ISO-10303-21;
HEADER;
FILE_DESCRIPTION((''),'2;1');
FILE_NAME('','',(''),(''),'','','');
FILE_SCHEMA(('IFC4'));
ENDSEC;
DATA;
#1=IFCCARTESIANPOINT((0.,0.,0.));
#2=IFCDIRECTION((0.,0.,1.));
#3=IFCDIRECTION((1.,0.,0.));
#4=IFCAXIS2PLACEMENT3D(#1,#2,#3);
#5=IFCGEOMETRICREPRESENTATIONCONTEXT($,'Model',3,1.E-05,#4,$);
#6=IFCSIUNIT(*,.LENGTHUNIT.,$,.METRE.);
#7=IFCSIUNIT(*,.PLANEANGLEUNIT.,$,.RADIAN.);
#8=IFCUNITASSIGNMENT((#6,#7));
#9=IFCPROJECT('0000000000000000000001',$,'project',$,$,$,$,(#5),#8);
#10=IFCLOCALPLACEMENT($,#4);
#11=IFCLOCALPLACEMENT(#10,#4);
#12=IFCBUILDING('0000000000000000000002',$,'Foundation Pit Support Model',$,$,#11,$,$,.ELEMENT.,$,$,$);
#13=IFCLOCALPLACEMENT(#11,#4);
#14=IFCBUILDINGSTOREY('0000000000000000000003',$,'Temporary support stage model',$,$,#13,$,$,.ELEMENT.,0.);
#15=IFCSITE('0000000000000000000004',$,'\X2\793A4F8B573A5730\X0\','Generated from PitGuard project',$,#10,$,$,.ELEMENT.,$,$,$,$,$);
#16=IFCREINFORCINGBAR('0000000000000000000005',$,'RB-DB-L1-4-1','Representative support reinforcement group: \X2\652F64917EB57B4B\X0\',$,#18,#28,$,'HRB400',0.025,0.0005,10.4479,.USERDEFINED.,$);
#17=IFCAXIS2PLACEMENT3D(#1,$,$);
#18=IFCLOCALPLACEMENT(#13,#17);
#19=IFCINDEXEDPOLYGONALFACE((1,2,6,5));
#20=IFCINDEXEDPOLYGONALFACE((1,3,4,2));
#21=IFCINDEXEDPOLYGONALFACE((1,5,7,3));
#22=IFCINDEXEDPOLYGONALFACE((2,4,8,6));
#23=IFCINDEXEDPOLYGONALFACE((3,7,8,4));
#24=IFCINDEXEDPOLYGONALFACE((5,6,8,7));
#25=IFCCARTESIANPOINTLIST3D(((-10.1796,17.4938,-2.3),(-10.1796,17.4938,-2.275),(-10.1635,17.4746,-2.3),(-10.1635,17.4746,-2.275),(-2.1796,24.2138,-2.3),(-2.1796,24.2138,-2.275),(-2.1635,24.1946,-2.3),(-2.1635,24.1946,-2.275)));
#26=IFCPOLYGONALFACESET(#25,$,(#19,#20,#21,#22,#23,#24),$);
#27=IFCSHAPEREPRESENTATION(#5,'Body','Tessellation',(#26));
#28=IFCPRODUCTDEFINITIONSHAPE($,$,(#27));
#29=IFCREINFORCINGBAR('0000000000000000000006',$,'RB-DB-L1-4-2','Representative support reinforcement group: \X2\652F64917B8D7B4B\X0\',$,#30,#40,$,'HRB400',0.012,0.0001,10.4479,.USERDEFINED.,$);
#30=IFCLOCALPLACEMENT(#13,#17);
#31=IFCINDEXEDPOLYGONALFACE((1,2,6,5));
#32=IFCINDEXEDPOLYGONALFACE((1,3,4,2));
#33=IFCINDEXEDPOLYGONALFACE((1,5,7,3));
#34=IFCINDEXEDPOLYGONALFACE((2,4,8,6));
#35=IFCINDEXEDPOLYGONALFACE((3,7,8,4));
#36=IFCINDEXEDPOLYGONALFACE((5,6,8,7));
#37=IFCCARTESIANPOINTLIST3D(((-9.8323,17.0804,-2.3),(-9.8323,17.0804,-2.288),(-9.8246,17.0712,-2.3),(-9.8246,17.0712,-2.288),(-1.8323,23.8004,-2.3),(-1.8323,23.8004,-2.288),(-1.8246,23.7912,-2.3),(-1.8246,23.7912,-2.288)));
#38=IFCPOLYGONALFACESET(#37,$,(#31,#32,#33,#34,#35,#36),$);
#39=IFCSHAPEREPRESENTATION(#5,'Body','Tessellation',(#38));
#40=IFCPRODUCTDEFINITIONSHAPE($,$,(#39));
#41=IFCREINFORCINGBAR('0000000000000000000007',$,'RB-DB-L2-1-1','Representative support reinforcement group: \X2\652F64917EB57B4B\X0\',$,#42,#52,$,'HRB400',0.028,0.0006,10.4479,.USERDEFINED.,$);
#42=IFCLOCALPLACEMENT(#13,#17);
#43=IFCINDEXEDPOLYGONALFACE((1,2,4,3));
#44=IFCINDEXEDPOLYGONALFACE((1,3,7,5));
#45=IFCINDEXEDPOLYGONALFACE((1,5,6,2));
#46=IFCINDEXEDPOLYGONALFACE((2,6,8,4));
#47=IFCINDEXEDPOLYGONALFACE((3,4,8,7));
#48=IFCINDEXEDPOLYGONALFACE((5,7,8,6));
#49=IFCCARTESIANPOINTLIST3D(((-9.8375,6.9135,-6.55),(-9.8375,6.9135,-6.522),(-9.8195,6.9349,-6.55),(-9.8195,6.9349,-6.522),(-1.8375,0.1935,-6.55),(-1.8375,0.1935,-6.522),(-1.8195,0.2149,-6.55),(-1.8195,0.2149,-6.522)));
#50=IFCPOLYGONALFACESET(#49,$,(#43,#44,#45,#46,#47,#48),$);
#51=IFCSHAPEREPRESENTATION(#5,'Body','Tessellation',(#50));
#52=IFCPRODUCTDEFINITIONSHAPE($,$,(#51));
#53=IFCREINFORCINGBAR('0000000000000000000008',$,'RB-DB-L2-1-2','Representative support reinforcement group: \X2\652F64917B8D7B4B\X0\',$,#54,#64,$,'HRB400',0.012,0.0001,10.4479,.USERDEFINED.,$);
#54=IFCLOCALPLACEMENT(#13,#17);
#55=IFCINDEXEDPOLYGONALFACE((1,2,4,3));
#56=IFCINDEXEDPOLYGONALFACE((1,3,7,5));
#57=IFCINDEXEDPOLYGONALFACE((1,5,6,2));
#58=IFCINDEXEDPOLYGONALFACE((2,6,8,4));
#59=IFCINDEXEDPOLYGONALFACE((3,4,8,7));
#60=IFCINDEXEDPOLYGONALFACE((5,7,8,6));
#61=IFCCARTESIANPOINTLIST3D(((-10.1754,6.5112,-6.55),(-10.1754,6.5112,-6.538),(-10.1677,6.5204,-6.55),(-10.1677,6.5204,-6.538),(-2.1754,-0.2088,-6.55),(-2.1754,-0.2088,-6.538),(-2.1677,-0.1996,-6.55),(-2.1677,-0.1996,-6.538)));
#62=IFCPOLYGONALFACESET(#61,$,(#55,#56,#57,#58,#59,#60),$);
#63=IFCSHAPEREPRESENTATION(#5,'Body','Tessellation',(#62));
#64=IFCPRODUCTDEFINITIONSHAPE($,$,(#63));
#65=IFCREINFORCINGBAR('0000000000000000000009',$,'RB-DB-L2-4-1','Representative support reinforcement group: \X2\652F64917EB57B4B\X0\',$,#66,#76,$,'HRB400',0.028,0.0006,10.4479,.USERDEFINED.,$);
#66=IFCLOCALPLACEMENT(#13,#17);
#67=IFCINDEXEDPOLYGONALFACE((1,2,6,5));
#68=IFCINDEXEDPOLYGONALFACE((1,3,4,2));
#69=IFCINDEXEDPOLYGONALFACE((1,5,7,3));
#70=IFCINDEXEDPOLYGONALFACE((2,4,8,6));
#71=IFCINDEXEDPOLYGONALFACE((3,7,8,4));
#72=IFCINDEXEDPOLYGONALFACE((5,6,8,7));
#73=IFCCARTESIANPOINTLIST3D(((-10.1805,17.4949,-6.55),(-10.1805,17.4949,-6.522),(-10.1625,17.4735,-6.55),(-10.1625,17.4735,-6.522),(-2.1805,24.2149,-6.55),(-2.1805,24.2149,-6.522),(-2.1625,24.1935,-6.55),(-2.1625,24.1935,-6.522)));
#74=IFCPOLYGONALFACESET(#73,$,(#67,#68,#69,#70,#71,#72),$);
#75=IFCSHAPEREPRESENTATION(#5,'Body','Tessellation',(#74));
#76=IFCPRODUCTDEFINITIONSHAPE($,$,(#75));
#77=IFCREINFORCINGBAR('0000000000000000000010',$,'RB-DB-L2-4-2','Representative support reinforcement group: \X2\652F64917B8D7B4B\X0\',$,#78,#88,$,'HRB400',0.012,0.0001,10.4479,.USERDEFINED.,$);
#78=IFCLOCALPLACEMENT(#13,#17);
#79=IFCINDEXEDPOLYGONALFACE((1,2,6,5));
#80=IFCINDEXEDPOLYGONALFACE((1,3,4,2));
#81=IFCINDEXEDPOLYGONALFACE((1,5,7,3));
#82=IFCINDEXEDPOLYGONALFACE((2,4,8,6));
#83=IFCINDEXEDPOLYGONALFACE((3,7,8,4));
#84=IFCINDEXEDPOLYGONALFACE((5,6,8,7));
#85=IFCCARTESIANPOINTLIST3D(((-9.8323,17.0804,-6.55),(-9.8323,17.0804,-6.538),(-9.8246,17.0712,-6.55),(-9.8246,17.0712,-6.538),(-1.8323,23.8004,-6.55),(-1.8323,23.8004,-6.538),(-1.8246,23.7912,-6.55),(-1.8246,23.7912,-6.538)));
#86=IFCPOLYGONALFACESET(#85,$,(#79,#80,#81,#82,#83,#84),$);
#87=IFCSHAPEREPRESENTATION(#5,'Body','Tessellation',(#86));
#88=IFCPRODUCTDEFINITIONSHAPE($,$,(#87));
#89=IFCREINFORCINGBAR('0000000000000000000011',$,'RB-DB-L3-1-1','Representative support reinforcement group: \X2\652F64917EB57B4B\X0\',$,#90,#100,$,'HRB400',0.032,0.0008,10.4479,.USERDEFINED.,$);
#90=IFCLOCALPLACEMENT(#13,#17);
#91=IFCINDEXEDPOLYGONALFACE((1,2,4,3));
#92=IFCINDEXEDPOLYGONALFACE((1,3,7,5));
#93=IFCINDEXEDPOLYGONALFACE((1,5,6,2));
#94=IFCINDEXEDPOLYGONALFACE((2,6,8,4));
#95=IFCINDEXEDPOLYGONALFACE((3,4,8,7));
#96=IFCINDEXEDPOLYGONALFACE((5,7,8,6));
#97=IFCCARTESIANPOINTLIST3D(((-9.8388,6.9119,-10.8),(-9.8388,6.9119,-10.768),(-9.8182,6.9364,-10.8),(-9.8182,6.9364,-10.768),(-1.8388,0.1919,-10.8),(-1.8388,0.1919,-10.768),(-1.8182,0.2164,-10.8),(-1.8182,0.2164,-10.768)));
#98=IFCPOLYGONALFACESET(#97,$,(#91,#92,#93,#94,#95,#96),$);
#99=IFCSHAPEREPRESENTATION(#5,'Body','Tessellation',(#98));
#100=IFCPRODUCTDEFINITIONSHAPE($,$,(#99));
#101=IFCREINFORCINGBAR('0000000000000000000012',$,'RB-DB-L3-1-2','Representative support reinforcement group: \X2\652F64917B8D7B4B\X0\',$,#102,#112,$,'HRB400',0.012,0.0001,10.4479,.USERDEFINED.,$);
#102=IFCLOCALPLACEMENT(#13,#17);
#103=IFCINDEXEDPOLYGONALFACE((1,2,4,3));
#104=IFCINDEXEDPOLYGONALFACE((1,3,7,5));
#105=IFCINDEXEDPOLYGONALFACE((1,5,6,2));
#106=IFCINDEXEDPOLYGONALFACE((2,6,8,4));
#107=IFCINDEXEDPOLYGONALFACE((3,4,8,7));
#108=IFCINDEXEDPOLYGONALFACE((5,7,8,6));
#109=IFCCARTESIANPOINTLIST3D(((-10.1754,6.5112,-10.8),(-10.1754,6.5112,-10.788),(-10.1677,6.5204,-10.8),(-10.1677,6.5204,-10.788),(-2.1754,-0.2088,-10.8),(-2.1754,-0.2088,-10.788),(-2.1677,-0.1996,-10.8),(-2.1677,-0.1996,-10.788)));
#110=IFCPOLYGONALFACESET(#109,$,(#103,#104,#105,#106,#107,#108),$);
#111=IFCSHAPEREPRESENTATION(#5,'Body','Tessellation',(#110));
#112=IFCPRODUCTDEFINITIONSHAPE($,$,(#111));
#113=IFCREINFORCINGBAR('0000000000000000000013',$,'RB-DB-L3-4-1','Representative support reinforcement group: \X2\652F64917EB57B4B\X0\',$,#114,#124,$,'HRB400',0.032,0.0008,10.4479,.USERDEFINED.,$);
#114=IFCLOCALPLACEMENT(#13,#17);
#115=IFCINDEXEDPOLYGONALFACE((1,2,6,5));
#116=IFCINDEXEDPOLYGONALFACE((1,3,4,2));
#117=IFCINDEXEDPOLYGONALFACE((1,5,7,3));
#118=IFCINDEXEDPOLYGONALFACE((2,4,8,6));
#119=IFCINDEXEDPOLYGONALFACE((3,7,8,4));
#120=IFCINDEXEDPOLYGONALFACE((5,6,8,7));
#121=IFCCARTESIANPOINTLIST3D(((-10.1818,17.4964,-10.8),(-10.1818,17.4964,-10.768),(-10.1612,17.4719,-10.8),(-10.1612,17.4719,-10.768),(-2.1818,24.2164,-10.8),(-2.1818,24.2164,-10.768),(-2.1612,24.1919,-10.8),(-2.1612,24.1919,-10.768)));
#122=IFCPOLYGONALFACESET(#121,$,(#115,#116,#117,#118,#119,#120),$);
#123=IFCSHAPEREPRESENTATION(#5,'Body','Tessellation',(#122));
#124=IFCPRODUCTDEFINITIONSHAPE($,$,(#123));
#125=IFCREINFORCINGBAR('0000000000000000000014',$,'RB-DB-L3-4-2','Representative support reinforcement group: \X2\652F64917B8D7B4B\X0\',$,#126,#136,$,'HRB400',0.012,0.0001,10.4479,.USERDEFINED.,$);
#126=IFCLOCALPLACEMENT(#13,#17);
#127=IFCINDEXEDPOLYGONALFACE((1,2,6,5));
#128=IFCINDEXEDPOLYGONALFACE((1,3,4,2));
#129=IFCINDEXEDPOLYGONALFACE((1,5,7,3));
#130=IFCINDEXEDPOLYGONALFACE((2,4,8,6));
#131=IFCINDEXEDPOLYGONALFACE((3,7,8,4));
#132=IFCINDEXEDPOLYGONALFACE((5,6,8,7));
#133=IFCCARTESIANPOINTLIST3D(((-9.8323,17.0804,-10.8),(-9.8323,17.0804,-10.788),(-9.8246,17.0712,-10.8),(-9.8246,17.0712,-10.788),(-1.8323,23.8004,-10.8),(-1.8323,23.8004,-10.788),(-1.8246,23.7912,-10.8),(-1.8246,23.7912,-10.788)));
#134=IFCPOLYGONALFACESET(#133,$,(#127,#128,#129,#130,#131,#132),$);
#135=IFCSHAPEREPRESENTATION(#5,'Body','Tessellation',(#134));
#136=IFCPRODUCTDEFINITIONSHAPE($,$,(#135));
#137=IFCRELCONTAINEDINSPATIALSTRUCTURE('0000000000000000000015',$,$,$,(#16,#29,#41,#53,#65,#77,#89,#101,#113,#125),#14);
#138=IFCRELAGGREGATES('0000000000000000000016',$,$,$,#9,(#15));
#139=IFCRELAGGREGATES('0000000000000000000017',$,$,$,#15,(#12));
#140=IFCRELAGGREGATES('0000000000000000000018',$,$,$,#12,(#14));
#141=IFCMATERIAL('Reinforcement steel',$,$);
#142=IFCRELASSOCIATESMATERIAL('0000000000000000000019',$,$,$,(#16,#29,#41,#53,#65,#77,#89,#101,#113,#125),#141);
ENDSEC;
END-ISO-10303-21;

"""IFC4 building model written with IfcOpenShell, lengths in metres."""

from ifc_helpers import new_model, si_unit, frame, origin_with_axes, origin_2d, place, context, project, spatial, rectangle, extrude, material, element, save


model = new_model("IFC4")

# Units and contexts
model_context = context("Model", 3, precision=1e-05, world=origin_with_axes())
ifc_project = project(units=[si_unit("LENGTHUNIT", "METRE"), si_unit("PLANEANGLEUNIT", "RADIAN")], contexts=[model_context])

# Site, building, storey
site_placement = place(None, origin_with_axes())
site = spatial("IfcSite", under=ifc_project, at=site_placement, Name="示例场地", Description="Generated from PitGuard project", CompositionType="ELEMENT")
building_placement = place(site_placement, origin_with_axes())
building = spatial("IfcBuilding", under=site, at=building_placement, Name="Foundation Pit Support Model", CompositionType="ELEMENT")
storey_placement = place(building_placement, origin_with_axes())
storey = spatial("IfcBuildingStorey", under=building, at=storey_placement, Name="Temporary support stage model", CompositionType="ELEMENT", Elevation=0.0)

# Reinforcing bars
ifc_material_1 = material(Name="Reinforcement steel")
reinforcing_bar_1_placement = place(storey_placement, frame((-6.1715, 20.8442, -2.3), z_axis=(0.0, 0.0, 1.0), x_axis=(-0.765705, -0.643192, 0.0)))
element("IfcReinforcingBar", 1, at=reinforcing_bar_1_placement, inside=storey, material=ifc_material_1, Name="RB-DB-L1-4-1", Description="Representative support reinforcement group: 支撑纵筋", SteelGrade="HRB400", BarLength=10.4479, CrossSectionArea=0.0005, NominalDiameter=0.025, PredefinedType="USERDEFINED", context=model_context, shape_type="SweptSolid", body=[
    extrude(rectangle(XDim=10.4479, YDim=0.025, at=origin_2d()), origin_with_axes(), (0.0, 0.0, 1.0), 0.025),
])
reinforcing_bar_2_placement = place(storey_placement, frame((-5.8285, 20.4358, -2.3), z_axis=(0.0, 0.0, 1.0), x_axis=(-0.765705, -0.643192, 0.0)))
element("IfcReinforcingBar", 2, at=reinforcing_bar_2_placement, inside=storey, material=ifc_material_1, Name="RB-DB-L1-4-2", Description="Representative support reinforcement group: 支撑箍筋", SteelGrade="HRB400", BarLength=10.4479, CrossSectionArea=0.0001, NominalDiameter=0.012, PredefinedType="USERDEFINED", context=model_context, shape_type="SweptSolid", body=[
    extrude(rectangle(XDim=10.4479, YDim=0.012, at=origin_2d()), origin_with_axes(), (0.0, 0.0, 1.0), 0.012),
])
reinforcing_bar_3_placement = place(storey_placement, frame((-5.8285, 3.5642, -6.55), z_axis=(0.0, 0.0, 1.0), x_axis=(-0.765705, 0.643192, 0.0)))
element("IfcReinforcingBar", 3, at=reinforcing_bar_3_placement, inside=storey, material=ifc_material_1, Name="RB-DB-L2-1-1", Description="Representative support reinforcement group: 支撑纵筋", SteelGrade="HRB400", BarLength=10.4479, CrossSectionArea=0.0006, NominalDiameter=0.028, PredefinedType="USERDEFINED", context=model_context, shape_type="SweptSolid", body=[
    extrude(rectangle(XDim=10.4479, YDim=0.028, at=origin_2d()), origin_with_axes(), (0.0, 0.0, 1.0), 0.028),
])
reinforcing_bar_4_placement = place(storey_placement, frame((-6.1715, 3.1558, -6.55), z_axis=(0.0, 0.0, 1.0), x_axis=(-0.765705, 0.643192, 0.0)))
element("IfcReinforcingBar", 4, at=reinforcing_bar_4_placement, inside=storey, material=ifc_material_1, Name="RB-DB-L2-1-2", Description="Representative support reinforcement group: 支撑箍筋", SteelGrade="HRB400", BarLength=10.4479, CrossSectionArea=0.0001, NominalDiameter=0.012, PredefinedType="USERDEFINED", context=model_context, shape_type="SweptSolid", body=[
    extrude(rectangle(XDim=10.4479, YDim=0.012, at=origin_2d()), origin_with_axes(), (0.0, 0.0, 1.0), 0.012),
])
reinforcing_bar_5_placement = place(storey_placement, frame((-6.1715, 20.8442, -6.55), z_axis=(0.0, 0.0, 1.0), x_axis=(-0.765705, -0.643192, 0.0)))
element("IfcReinforcingBar", 5, at=reinforcing_bar_5_placement, inside=storey, material=ifc_material_1, Name="RB-DB-L2-4-1", Description="Representative support reinforcement group: 支撑纵筋", SteelGrade="HRB400", BarLength=10.4479, CrossSectionArea=0.0006, NominalDiameter=0.028, PredefinedType="USERDEFINED", context=model_context, shape_type="SweptSolid", body=[
    extrude(rectangle(XDim=10.4479, YDim=0.028, at=origin_2d()), origin_with_axes(), (0.0, 0.0, 1.0), 0.028),
])
reinforcing_bar_6_placement = place(storey_placement, frame((-5.8285, 20.4358, -6.55), z_axis=(0.0, 0.0, 1.0), x_axis=(-0.765705, -0.643192, 0.0)))
element("IfcReinforcingBar", 6, at=reinforcing_bar_6_placement, inside=storey, material=ifc_material_1, Name="RB-DB-L2-4-2", Description="Representative support reinforcement group: 支撑箍筋", SteelGrade="HRB400", BarLength=10.4479, CrossSectionArea=0.0001, NominalDiameter=0.012, PredefinedType="USERDEFINED", context=model_context, shape_type="SweptSolid", body=[
    extrude(rectangle(XDim=10.4479, YDim=0.012, at=origin_2d()), origin_with_axes(), (0.0, 0.0, 1.0), 0.012),
])
reinforcing_bar_7_placement = place(storey_placement, frame((-5.8285, 3.5642, -10.8), z_axis=(0.0, 0.0, 1.0), x_axis=(-0.765705, 0.643192, 0.0)))
element("IfcReinforcingBar", 7, at=reinforcing_bar_7_placement, inside=storey, material=ifc_material_1, Name="RB-DB-L3-1-1", Description="Representative support reinforcement group: 支撑纵筋", SteelGrade="HRB400", BarLength=10.4479, CrossSectionArea=0.0008, NominalDiameter=0.032, PredefinedType="USERDEFINED", context=model_context, shape_type="SweptSolid", body=[
    extrude(rectangle(XDim=10.4479, YDim=0.032, at=origin_2d()), origin_with_axes(), (0.0, 0.0, 1.0), 0.032),
])
reinforcing_bar_8_placement = place(storey_placement, frame((-6.1715, 3.1558, -10.8), z_axis=(0.0, 0.0, 1.0), x_axis=(-0.765705, 0.643192, 0.0)))
element("IfcReinforcingBar", 8, at=reinforcing_bar_8_placement, inside=storey, material=ifc_material_1, Name="RB-DB-L3-1-2", Description="Representative support reinforcement group: 支撑箍筋", SteelGrade="HRB400", BarLength=10.4479, CrossSectionArea=0.0001, NominalDiameter=0.012, PredefinedType="USERDEFINED", context=model_context, shape_type="SweptSolid", body=[
    extrude(rectangle(XDim=10.4479, YDim=0.012, at=origin_2d()), origin_with_axes(), (0.0, 0.0, 1.0), 0.012),
])
reinforcing_bar_9_placement = place(storey_placement, frame((-6.1715, 20.8442, -10.8), z_axis=(0.0, 0.0, 1.0), x_axis=(-0.765705, -0.643192, 0.0)))
element("IfcReinforcingBar", 9, at=reinforcing_bar_9_placement, inside=storey, material=ifc_material_1, Name="RB-DB-L3-4-1", Description="Representative support reinforcement group: 支撑纵筋", SteelGrade="HRB400", BarLength=10.4479, CrossSectionArea=0.0008, NominalDiameter=0.032, PredefinedType="USERDEFINED", context=model_context, shape_type="SweptSolid", body=[
    extrude(rectangle(XDim=10.4479, YDim=0.032, at=origin_2d()), origin_with_axes(), (0.0, 0.0, 1.0), 0.032),
])
reinforcing_bar_10_placement = place(storey_placement, frame((-5.8285, 20.4358, -10.8), z_axis=(0.0, 0.0, 1.0), x_axis=(-0.765705, -0.643192, 0.0)))
element("IfcReinforcingBar", 10, at=reinforcing_bar_10_placement, inside=storey, material=ifc_material_1, Name="RB-DB-L3-4-2", Description="Representative support reinforcement group: 支撑箍筋", SteelGrade="HRB400", BarLength=10.4479, CrossSectionArea=0.0001, NominalDiameter=0.012, PredefinedType="USERDEFINED", context=model_context, shape_type="SweptSolid", body=[
    extrude(rectangle(XDim=10.4479, YDim=0.012, at=origin_2d()), origin_with_axes(), (0.0, 0.0, 1.0), 0.012),
])

save(model, "model.ifc")
